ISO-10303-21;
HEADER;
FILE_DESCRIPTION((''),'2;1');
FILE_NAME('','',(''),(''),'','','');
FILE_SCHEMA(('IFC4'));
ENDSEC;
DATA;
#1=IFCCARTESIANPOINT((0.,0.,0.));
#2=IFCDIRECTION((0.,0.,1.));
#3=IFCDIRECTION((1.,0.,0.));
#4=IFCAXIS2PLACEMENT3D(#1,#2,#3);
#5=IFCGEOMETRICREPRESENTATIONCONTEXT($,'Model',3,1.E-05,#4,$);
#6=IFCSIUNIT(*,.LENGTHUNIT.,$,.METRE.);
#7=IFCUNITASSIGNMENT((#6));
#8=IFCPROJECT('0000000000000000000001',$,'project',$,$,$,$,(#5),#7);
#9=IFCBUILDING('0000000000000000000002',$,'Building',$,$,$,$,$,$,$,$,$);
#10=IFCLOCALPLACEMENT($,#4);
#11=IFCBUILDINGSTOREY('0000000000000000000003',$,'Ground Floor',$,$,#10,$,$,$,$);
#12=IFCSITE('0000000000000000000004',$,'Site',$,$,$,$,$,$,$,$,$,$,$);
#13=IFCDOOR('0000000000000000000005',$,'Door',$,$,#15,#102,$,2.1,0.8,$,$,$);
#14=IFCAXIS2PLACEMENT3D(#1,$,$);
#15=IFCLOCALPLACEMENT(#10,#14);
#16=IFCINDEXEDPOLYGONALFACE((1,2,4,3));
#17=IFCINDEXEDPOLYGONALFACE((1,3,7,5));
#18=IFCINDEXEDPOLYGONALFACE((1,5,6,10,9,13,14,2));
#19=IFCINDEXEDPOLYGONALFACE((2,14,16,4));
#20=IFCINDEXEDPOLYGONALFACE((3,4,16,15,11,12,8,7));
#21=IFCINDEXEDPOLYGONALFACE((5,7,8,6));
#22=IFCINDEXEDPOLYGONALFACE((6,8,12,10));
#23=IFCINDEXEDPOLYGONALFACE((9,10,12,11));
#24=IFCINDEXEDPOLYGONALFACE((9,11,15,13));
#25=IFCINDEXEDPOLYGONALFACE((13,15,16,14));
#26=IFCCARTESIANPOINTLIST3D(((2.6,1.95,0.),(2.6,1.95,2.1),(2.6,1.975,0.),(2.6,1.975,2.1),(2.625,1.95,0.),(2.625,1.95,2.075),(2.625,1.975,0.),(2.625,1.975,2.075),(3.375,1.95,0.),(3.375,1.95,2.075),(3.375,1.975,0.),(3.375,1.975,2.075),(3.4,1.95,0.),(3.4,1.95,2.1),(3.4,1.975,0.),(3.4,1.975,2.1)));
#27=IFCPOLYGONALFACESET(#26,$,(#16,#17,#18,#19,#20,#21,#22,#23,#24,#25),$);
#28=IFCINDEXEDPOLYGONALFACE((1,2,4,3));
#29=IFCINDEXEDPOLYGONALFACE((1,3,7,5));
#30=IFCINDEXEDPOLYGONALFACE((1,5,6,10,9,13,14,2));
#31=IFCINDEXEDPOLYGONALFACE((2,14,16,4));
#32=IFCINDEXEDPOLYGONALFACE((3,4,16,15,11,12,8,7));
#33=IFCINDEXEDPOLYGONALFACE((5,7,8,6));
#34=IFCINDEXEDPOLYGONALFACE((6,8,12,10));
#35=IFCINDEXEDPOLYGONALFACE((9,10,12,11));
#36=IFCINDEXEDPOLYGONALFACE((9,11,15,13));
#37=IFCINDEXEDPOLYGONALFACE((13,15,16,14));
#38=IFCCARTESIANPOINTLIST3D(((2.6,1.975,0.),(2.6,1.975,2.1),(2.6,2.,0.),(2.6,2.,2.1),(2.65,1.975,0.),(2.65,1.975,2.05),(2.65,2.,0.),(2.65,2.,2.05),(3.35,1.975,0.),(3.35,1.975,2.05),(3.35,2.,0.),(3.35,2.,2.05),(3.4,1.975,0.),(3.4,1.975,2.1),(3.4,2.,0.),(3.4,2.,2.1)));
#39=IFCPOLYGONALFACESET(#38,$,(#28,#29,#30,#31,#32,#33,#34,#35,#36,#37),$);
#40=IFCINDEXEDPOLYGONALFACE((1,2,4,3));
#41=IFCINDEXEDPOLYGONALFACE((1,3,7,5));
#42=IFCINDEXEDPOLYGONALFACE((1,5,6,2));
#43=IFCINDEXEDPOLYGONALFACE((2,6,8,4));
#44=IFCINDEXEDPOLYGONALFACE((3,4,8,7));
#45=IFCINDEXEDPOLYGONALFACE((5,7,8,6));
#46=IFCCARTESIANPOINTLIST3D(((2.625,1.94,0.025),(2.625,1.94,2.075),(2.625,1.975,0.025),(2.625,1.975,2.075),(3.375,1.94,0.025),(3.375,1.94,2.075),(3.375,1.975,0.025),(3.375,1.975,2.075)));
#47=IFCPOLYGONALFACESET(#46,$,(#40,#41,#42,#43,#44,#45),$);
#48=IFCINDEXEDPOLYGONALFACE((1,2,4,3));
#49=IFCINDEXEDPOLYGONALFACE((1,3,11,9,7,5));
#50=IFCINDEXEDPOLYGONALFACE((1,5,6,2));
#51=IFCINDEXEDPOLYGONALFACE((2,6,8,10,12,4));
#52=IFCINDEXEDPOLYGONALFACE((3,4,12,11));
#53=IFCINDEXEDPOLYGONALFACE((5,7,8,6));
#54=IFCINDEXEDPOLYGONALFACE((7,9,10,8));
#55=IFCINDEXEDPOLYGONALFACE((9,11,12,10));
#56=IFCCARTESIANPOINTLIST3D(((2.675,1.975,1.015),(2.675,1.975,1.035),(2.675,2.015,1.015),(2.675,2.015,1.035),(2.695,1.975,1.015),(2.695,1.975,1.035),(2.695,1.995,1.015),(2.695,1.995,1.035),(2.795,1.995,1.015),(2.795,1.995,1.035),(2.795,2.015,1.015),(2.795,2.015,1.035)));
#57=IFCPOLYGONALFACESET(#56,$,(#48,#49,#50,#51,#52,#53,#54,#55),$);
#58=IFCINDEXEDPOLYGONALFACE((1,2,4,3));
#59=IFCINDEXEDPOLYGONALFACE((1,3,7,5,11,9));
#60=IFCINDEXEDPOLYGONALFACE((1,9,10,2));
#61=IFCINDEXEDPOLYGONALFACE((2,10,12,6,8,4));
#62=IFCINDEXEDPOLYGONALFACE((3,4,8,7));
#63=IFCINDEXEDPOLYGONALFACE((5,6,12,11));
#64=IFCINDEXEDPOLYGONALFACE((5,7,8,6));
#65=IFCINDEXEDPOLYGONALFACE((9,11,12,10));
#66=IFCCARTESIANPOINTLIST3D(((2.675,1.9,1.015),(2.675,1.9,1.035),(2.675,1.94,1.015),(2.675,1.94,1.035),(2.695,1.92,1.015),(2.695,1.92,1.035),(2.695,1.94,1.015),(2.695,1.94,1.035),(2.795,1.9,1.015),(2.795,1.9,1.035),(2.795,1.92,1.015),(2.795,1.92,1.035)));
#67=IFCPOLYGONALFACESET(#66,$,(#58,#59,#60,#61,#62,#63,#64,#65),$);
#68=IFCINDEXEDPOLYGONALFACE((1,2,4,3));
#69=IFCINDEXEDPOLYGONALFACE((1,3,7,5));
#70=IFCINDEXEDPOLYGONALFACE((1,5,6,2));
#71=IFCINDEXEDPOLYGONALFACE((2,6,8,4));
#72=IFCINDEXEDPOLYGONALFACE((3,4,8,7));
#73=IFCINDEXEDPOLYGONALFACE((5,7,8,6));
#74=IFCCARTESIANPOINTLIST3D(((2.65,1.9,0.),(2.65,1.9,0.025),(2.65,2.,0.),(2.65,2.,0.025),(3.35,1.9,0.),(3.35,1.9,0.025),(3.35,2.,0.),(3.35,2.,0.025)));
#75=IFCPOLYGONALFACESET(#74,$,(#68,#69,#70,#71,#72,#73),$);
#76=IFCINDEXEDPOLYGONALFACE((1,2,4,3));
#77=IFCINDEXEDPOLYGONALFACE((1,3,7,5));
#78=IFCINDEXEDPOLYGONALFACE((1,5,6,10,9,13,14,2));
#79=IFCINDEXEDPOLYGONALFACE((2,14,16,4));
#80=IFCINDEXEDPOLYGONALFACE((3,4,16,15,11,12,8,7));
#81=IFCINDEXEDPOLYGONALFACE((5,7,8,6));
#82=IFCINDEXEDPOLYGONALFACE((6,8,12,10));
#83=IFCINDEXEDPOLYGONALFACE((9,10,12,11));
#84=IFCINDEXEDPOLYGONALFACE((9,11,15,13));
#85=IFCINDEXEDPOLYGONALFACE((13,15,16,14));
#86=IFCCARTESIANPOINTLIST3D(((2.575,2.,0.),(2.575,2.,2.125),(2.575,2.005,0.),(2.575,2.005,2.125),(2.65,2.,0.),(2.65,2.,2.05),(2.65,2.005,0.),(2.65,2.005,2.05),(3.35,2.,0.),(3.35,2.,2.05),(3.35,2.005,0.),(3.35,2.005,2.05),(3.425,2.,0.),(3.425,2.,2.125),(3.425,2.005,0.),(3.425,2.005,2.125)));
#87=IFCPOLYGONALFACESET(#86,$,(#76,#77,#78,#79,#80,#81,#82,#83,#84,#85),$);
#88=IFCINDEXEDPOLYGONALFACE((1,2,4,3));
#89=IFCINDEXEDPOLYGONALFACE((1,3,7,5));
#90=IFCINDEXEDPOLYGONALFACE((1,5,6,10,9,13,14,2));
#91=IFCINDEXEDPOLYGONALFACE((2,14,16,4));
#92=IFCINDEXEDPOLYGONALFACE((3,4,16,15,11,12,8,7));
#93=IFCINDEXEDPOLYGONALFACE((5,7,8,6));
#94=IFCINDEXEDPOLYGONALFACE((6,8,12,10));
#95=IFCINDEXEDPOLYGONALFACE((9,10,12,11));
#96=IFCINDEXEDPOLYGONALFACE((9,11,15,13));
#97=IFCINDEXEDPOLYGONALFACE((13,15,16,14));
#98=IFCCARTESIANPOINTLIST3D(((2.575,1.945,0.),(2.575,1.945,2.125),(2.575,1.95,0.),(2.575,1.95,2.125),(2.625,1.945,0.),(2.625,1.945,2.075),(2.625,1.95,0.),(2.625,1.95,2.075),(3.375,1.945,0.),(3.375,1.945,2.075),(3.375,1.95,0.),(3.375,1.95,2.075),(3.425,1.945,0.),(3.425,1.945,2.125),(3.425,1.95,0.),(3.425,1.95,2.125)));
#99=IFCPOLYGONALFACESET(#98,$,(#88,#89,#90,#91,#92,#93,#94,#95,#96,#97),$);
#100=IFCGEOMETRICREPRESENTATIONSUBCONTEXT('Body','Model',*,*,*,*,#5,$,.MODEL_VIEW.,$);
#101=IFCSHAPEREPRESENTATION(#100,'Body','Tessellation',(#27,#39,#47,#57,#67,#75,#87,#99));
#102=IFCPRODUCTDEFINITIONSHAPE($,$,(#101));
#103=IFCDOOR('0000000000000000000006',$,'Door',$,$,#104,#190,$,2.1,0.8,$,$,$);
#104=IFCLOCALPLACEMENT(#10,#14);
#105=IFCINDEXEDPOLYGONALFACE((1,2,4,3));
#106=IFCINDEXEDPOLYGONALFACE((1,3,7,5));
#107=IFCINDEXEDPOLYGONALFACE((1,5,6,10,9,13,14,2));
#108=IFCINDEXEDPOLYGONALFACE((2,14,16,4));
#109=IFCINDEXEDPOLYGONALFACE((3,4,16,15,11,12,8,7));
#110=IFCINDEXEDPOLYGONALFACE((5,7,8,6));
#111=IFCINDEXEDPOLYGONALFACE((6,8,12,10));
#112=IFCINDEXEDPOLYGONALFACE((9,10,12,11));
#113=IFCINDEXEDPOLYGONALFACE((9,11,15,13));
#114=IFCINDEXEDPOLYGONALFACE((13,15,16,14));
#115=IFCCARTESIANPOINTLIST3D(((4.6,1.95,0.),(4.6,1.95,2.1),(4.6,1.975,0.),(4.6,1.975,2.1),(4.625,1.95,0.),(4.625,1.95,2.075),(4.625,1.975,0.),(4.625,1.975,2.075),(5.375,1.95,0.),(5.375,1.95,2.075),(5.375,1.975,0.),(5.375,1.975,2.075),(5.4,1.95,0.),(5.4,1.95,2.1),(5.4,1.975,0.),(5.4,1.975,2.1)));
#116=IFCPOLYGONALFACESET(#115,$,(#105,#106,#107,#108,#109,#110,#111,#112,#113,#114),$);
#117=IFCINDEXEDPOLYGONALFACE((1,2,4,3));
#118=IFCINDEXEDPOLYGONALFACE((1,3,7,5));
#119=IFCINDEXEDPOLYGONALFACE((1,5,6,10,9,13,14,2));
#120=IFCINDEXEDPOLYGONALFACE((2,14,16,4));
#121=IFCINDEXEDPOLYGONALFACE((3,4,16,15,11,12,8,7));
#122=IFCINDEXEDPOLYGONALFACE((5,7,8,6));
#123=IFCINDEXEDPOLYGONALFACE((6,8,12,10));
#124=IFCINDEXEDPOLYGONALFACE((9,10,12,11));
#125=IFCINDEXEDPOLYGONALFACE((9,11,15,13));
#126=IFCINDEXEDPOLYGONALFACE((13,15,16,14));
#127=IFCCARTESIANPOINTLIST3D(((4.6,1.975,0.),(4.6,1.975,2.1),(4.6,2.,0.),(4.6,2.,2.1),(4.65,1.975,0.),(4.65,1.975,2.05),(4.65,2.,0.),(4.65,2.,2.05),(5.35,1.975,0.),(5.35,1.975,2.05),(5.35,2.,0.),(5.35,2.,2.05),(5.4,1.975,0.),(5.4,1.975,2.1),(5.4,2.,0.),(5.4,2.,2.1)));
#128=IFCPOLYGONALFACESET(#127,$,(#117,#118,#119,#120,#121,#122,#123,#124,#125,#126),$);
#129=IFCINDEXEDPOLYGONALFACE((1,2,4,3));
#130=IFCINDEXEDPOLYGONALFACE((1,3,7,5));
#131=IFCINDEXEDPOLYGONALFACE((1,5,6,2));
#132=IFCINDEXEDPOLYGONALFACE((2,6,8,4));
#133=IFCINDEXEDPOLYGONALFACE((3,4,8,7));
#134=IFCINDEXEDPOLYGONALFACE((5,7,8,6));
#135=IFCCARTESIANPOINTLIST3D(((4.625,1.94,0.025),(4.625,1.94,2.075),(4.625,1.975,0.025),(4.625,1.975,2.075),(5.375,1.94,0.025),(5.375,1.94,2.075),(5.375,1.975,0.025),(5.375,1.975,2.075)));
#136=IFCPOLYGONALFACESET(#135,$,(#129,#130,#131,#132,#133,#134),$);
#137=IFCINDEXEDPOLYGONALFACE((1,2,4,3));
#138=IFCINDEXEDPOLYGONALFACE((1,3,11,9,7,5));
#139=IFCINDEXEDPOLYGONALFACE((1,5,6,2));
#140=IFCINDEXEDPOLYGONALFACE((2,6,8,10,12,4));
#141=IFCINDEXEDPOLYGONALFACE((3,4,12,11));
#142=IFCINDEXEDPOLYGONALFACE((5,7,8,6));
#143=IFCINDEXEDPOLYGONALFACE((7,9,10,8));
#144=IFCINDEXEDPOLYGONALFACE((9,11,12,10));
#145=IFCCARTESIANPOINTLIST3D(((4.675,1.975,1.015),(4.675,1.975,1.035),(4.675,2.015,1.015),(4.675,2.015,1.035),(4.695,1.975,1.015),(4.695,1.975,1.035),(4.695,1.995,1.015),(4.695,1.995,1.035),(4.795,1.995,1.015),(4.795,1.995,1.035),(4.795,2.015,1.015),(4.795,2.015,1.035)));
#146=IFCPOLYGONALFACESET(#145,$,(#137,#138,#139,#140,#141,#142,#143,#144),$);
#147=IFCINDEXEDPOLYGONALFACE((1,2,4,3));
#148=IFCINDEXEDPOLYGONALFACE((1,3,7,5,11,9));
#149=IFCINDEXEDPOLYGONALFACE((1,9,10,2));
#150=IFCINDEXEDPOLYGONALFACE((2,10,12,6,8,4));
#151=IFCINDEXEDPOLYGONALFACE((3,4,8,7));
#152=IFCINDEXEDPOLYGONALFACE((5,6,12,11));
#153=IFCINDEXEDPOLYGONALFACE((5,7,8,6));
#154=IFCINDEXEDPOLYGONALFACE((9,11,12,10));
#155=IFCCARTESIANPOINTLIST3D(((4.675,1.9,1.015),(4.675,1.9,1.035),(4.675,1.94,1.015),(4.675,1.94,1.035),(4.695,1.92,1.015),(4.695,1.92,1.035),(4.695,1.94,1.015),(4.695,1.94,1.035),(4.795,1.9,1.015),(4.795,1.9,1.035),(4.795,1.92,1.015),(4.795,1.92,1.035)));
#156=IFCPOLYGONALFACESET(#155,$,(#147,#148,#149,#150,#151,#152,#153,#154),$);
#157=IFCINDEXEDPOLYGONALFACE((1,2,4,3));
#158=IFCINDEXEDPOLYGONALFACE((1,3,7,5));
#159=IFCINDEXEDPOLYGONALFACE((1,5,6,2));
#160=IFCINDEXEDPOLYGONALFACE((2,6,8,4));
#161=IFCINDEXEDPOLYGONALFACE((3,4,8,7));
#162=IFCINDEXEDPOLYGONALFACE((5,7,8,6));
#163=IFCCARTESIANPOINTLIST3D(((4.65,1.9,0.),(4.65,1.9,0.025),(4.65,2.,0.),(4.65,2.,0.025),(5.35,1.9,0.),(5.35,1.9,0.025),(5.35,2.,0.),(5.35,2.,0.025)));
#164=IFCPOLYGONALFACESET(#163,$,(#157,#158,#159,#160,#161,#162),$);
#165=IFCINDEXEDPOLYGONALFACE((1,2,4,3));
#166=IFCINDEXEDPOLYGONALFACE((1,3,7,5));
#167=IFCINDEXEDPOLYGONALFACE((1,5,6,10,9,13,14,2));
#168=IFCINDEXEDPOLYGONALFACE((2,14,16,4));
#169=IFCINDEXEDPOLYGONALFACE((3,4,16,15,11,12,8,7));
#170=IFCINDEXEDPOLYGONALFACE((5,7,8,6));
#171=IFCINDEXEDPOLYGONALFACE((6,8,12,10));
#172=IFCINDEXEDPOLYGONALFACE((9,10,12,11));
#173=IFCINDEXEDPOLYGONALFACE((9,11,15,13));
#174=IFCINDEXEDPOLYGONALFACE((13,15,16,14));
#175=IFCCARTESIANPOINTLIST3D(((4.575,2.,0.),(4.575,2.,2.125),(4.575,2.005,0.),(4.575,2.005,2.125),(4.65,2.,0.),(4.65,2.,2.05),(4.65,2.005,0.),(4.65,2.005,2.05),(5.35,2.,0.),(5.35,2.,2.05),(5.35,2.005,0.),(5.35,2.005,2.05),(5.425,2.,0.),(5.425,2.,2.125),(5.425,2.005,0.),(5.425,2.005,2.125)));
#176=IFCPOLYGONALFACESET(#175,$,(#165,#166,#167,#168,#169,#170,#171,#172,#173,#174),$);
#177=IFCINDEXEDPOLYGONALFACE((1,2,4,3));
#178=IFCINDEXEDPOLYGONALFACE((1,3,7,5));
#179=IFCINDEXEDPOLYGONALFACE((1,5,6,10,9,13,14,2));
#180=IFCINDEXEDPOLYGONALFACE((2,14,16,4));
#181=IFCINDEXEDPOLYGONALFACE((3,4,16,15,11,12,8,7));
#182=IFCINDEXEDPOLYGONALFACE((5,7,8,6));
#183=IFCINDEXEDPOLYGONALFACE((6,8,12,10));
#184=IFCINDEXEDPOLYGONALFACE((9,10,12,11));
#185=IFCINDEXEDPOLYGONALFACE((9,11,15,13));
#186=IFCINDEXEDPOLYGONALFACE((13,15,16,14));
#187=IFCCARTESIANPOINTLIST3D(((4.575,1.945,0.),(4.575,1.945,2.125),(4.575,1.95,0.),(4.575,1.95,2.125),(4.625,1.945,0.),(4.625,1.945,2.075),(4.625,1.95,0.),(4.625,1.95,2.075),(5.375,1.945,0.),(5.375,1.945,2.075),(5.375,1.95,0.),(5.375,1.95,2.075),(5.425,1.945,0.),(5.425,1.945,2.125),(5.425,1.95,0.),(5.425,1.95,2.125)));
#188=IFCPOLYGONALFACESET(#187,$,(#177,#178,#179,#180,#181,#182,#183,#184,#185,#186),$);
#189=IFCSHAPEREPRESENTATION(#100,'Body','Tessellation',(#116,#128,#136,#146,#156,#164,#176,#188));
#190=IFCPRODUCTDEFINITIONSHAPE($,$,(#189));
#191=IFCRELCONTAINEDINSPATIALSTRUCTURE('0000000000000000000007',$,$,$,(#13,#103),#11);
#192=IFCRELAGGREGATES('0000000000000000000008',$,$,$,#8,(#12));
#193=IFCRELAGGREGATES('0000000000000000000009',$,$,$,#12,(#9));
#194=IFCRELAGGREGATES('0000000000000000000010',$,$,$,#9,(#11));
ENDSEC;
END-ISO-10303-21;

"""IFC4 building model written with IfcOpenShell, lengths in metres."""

from ifc_helpers import new_model, si_unit, frame, origin_with_axes, place, context, subcontext, project, spatial, line, indexed_curve, outline, extrude, element, save


model = new_model("IFC4")

# Units and contexts
model_context = context("Model", 3, precision=1e-05, world=origin_with_axes())
body_context = subcontext(model_context, "Body", "Model", "MODEL_VIEW")
ifc_project = project(units=[si_unit("LENGTHUNIT", "METRE")], contexts=[model_context])

# Site, building, storey
site = spatial("IfcSite", under=ifc_project, Name="Site")
building = spatial("IfcBuilding", under=site, Name="Building")
storey_placement = place(None, origin_with_axes())
storey = spatial("IfcBuildingStorey", under=building, at=storey_placement, Name="Ground Floor")

# Doors
door_1_placement = place(storey_placement, frame((3.4, 2.0, 0.0), z_axis=(0.0, 0.0, 1.0), x_axis=(-1.0, 0.0, 0.0)))
element("IfcDoor", 1, at=door_1_placement, inside=storey, Name="Door", OverallHeight=2.1, OverallWidth=0.8, context=body_context, shape_type="SweptSolid", body=[
    extrude(outline(indexed_curve([(0.0, 0.0), (0.0, 2.1), (0.8, 2.1), (0.8, 0.0), (0.775, 0.0), (0.775, 2.075), (0.025, 2.075), (0.025, 0.0)], segments=[line(1, 2, 3, 4, 5, 6, 7, 8, 1)])), frame((0.0, 0.025, 0.0), z_axis=(0.0, -1.0, 0.0), x_axis=(1.0, 0.0, 0.0)), (0.0, 0.0, -1.0), 0.025),
    extrude(outline(indexed_curve([(0.0, 0.0), (0.0, 2.1), (0.8, 2.1), (0.8, 0.0), (0.75, 0.0), (0.75, 2.05), (0.05, 2.05), (0.05, 0.0)], segments=[line(1, 2, 3, 4, 5, 6, 7, 8, 1)])), frame((0.0, 0.0, 0.0), z_axis=(0.0, -1.0, 0.0), x_axis=(1.0, 0.0, 0.0)), (0.0, 0.0, -1.0), 0.025),
    extrude(outline(indexed_curve([(0.0, 0.0), (0.75, 0.0), (0.75, 0.035), (0.0, 0.035)], segments=[line(1, 2, 3, 4, 1)])), frame((0.025, 0.025, 0.025), z_axis=(0.0, 0.0, 1.0), x_axis=(1.0, 0.0, 0.0)), (0.0, 0.0, 1.0), 2.05),
    extrude(outline(indexed_curve([(0.0, 0.0), (0.0, -0.04), (-0.12, -0.04), (-0.12, -0.02), (-0.02, -0.02), (-0.02, 0.0)], segments=[line(1, 2, 3, 4, 5, 6, 1)])), frame((0.725, 0.025, 1.015), z_axis=(0.0, 0.0, 1.0), x_axis=(1.0, 0.0, 0.0)), (0.0, 0.0, 1.0), 0.02),
    extrude(outline(indexed_curve([(0.0, 0.0), (0.0, 0.04), (-0.12, 0.04), (-0.12, 0.02), (-0.02, 0.02), (-0.02, 0.0)], segments=[line(1, 2, 3, 4, 5, 6, 1)])), frame((0.725, 0.06, 1.015), z_axis=(0.0, 0.0, 1.0), x_axis=(1.0, 0.0, 0.0)), (0.0, 0.0, 1.0), 0.02),
    extrude(outline(indexed_curve([(0.0, 0.0), (0.7, 0.0), (0.7, 0.1), (0.0, 0.1)], segments=[line(1, 2, 3, 4, 1)])), frame((0.05, 0.0, 0.0), z_axis=(0.0, 0.0, 1.0), x_axis=(1.0, 0.0, 0.0)), (0.0, 0.0, 1.0), 0.025),
    extrude(outline(indexed_curve([(0.0, 0.0), (0.0, 2.125), (0.85, 2.125), (0.85, 0.0), (0.775, 0.0), (0.775, 2.05), (0.075, 2.05), (0.075, 0.0)], segments=[line(1, 2, 3, 4, 5, 6, 7, 8, 1)])), frame((-0.025, -0.005, 0.0), z_axis=(0.0, -1.0, 0.0), x_axis=(1.0, 0.0, 0.0)), (0.0, 0.0, -1.0), 0.005),
    extrude(outline(indexed_curve([(0.0, 0.0), (0.0, 2.125), (0.85, 2.125), (0.85, 0.0), (0.8, 0.0), (0.8, 2.075), (0.05, 2.075), (0.05, 0.0)], segments=[line(1, 2, 3, 4, 5, 6, 7, 8, 1)])), frame((-0.025, 0.05, 0.0), z_axis=(0.0, -1.0, 0.0), x_axis=(1.0, 0.0, 0.0)), (0.0, 0.0, -1.0), 0.005),
])
door_2_placement = place(storey_placement, frame((5.4, 2.0, 0.0), z_axis=(0.0, 0.0, 1.0), x_axis=(-1.0, 0.0, 0.0)))
element("IfcDoor", 2, at=door_2_placement, inside=storey, Name="Door", OverallHeight=2.1, OverallWidth=0.8, context=body_context, shape_type="SweptSolid", body=[
    extrude(outline(indexed_curve([(0.0, 0.0), (0.0, 2.1), (0.8, 2.1), (0.8, 0.0), (0.775, 0.0), (0.775, 2.075), (0.025, 2.075), (0.025, 0.0)], segments=[line(1, 2, 3, 4, 5, 6, 7, 8, 1)])), frame((0.0, 0.025, 0.0), z_axis=(0.0, -1.0, 0.0), x_axis=(1.0, 0.0, 0.0)), (0.0, 0.0, -1.0), 0.025),
    extrude(outline(indexed_curve([(0.0, 0.0), (0.0, 2.1), (0.8, 2.1), (0.8, 0.0), (0.75, 0.0), (0.75, 2.05), (0.05, 2.05), (0.05, 0.0)], segments=[line(1, 2, 3, 4, 5, 6, 7, 8, 1)])), frame((0.0, 0.0, 0.0), z_axis=(0.0, -1.0, 0.0), x_axis=(1.0, 0.0, 0.0)), (0.0, 0.0, -1.0), 0.025),
    extrude(outline(indexed_curve([(0.0, 0.0), (0.75, 0.0), (0.75, 0.035), (0.0, 0.035)], segments=[line(1, 2, 3, 4, 1)])), frame((0.025, 0.025, 0.025), z_axis=(0.0, 0.0, 1.0), x_axis=(1.0, 0.0, 0.0)), (0.0, 0.0, 1.0), 2.05),
    extrude(outline(indexed_curve([(0.0, 0.0), (0.0, -0.04), (-0.12, -0.04), (-0.12, -0.02), (-0.02, -0.02), (-0.02, 0.0)], segments=[line(1, 2, 3, 4, 5, 6, 1)])), frame((0.725, 0.025, 1.015), z_axis=(0.0, 0.0, 1.0), x_axis=(1.0, 0.0, 0.0)), (0.0, 0.0, 1.0), 0.02),
    extrude(outline(indexed_curve([(0.0, 0.0), (0.0, 0.04), (-0.12, 0.04), (-0.12, 0.02), (-0.02, 0.02), (-0.02, 0.0)], segments=[line(1, 2, 3, 4, 5, 6, 1)])), frame((0.725, 0.06, 1.015), z_axis=(0.0, 0.0, 1.0), x_axis=(1.0, 0.0, 0.0)), (0.0, 0.0, 1.0), 0.02),
    extrude(outline(indexed_curve([(0.0, 0.0), (0.7, 0.0), (0.7, 0.1), (0.0, 0.1)], segments=[line(1, 2, 3, 4, 1)])), frame((0.05, 0.0, 0.0), z_axis=(0.0, 0.0, 1.0), x_axis=(1.0, 0.0, 0.0)), (0.0, 0.0, 1.0), 0.025),
    extrude(outline(indexed_curve([(0.0, 0.0), (0.0, 2.125), (0.85, 2.125), (0.85, 0.0), (0.775, 0.0), (0.775, 2.05), (0.075, 2.05), (0.075, 0.0)], segments=[line(1, 2, 3, 4, 5, 6, 7, 8, 1)])), frame((-0.025, -0.005, 0.0), z_axis=(0.0, -1.0, 0.0), x_axis=(1.0, 0.0, 0.0)), (0.0, 0.0, -1.0), 0.005),
    extrude(outline(indexed_curve([(0.0, 0.0), (0.0, 2.125), (0.85, 2.125), (0.85, 0.0), (0.8, 0.0), (0.8, 2.075), (0.05, 2.075), (0.05, 0.0)], segments=[line(1, 2, 3, 4, 5, 6, 7, 8, 1)])), frame((-0.025, 0.05, 0.0), z_axis=(0.0, -1.0, 0.0), x_axis=(1.0, 0.0, 0.0)), (0.0, 0.0, -1.0), 0.005),
])

save(model, "model.ifc")
